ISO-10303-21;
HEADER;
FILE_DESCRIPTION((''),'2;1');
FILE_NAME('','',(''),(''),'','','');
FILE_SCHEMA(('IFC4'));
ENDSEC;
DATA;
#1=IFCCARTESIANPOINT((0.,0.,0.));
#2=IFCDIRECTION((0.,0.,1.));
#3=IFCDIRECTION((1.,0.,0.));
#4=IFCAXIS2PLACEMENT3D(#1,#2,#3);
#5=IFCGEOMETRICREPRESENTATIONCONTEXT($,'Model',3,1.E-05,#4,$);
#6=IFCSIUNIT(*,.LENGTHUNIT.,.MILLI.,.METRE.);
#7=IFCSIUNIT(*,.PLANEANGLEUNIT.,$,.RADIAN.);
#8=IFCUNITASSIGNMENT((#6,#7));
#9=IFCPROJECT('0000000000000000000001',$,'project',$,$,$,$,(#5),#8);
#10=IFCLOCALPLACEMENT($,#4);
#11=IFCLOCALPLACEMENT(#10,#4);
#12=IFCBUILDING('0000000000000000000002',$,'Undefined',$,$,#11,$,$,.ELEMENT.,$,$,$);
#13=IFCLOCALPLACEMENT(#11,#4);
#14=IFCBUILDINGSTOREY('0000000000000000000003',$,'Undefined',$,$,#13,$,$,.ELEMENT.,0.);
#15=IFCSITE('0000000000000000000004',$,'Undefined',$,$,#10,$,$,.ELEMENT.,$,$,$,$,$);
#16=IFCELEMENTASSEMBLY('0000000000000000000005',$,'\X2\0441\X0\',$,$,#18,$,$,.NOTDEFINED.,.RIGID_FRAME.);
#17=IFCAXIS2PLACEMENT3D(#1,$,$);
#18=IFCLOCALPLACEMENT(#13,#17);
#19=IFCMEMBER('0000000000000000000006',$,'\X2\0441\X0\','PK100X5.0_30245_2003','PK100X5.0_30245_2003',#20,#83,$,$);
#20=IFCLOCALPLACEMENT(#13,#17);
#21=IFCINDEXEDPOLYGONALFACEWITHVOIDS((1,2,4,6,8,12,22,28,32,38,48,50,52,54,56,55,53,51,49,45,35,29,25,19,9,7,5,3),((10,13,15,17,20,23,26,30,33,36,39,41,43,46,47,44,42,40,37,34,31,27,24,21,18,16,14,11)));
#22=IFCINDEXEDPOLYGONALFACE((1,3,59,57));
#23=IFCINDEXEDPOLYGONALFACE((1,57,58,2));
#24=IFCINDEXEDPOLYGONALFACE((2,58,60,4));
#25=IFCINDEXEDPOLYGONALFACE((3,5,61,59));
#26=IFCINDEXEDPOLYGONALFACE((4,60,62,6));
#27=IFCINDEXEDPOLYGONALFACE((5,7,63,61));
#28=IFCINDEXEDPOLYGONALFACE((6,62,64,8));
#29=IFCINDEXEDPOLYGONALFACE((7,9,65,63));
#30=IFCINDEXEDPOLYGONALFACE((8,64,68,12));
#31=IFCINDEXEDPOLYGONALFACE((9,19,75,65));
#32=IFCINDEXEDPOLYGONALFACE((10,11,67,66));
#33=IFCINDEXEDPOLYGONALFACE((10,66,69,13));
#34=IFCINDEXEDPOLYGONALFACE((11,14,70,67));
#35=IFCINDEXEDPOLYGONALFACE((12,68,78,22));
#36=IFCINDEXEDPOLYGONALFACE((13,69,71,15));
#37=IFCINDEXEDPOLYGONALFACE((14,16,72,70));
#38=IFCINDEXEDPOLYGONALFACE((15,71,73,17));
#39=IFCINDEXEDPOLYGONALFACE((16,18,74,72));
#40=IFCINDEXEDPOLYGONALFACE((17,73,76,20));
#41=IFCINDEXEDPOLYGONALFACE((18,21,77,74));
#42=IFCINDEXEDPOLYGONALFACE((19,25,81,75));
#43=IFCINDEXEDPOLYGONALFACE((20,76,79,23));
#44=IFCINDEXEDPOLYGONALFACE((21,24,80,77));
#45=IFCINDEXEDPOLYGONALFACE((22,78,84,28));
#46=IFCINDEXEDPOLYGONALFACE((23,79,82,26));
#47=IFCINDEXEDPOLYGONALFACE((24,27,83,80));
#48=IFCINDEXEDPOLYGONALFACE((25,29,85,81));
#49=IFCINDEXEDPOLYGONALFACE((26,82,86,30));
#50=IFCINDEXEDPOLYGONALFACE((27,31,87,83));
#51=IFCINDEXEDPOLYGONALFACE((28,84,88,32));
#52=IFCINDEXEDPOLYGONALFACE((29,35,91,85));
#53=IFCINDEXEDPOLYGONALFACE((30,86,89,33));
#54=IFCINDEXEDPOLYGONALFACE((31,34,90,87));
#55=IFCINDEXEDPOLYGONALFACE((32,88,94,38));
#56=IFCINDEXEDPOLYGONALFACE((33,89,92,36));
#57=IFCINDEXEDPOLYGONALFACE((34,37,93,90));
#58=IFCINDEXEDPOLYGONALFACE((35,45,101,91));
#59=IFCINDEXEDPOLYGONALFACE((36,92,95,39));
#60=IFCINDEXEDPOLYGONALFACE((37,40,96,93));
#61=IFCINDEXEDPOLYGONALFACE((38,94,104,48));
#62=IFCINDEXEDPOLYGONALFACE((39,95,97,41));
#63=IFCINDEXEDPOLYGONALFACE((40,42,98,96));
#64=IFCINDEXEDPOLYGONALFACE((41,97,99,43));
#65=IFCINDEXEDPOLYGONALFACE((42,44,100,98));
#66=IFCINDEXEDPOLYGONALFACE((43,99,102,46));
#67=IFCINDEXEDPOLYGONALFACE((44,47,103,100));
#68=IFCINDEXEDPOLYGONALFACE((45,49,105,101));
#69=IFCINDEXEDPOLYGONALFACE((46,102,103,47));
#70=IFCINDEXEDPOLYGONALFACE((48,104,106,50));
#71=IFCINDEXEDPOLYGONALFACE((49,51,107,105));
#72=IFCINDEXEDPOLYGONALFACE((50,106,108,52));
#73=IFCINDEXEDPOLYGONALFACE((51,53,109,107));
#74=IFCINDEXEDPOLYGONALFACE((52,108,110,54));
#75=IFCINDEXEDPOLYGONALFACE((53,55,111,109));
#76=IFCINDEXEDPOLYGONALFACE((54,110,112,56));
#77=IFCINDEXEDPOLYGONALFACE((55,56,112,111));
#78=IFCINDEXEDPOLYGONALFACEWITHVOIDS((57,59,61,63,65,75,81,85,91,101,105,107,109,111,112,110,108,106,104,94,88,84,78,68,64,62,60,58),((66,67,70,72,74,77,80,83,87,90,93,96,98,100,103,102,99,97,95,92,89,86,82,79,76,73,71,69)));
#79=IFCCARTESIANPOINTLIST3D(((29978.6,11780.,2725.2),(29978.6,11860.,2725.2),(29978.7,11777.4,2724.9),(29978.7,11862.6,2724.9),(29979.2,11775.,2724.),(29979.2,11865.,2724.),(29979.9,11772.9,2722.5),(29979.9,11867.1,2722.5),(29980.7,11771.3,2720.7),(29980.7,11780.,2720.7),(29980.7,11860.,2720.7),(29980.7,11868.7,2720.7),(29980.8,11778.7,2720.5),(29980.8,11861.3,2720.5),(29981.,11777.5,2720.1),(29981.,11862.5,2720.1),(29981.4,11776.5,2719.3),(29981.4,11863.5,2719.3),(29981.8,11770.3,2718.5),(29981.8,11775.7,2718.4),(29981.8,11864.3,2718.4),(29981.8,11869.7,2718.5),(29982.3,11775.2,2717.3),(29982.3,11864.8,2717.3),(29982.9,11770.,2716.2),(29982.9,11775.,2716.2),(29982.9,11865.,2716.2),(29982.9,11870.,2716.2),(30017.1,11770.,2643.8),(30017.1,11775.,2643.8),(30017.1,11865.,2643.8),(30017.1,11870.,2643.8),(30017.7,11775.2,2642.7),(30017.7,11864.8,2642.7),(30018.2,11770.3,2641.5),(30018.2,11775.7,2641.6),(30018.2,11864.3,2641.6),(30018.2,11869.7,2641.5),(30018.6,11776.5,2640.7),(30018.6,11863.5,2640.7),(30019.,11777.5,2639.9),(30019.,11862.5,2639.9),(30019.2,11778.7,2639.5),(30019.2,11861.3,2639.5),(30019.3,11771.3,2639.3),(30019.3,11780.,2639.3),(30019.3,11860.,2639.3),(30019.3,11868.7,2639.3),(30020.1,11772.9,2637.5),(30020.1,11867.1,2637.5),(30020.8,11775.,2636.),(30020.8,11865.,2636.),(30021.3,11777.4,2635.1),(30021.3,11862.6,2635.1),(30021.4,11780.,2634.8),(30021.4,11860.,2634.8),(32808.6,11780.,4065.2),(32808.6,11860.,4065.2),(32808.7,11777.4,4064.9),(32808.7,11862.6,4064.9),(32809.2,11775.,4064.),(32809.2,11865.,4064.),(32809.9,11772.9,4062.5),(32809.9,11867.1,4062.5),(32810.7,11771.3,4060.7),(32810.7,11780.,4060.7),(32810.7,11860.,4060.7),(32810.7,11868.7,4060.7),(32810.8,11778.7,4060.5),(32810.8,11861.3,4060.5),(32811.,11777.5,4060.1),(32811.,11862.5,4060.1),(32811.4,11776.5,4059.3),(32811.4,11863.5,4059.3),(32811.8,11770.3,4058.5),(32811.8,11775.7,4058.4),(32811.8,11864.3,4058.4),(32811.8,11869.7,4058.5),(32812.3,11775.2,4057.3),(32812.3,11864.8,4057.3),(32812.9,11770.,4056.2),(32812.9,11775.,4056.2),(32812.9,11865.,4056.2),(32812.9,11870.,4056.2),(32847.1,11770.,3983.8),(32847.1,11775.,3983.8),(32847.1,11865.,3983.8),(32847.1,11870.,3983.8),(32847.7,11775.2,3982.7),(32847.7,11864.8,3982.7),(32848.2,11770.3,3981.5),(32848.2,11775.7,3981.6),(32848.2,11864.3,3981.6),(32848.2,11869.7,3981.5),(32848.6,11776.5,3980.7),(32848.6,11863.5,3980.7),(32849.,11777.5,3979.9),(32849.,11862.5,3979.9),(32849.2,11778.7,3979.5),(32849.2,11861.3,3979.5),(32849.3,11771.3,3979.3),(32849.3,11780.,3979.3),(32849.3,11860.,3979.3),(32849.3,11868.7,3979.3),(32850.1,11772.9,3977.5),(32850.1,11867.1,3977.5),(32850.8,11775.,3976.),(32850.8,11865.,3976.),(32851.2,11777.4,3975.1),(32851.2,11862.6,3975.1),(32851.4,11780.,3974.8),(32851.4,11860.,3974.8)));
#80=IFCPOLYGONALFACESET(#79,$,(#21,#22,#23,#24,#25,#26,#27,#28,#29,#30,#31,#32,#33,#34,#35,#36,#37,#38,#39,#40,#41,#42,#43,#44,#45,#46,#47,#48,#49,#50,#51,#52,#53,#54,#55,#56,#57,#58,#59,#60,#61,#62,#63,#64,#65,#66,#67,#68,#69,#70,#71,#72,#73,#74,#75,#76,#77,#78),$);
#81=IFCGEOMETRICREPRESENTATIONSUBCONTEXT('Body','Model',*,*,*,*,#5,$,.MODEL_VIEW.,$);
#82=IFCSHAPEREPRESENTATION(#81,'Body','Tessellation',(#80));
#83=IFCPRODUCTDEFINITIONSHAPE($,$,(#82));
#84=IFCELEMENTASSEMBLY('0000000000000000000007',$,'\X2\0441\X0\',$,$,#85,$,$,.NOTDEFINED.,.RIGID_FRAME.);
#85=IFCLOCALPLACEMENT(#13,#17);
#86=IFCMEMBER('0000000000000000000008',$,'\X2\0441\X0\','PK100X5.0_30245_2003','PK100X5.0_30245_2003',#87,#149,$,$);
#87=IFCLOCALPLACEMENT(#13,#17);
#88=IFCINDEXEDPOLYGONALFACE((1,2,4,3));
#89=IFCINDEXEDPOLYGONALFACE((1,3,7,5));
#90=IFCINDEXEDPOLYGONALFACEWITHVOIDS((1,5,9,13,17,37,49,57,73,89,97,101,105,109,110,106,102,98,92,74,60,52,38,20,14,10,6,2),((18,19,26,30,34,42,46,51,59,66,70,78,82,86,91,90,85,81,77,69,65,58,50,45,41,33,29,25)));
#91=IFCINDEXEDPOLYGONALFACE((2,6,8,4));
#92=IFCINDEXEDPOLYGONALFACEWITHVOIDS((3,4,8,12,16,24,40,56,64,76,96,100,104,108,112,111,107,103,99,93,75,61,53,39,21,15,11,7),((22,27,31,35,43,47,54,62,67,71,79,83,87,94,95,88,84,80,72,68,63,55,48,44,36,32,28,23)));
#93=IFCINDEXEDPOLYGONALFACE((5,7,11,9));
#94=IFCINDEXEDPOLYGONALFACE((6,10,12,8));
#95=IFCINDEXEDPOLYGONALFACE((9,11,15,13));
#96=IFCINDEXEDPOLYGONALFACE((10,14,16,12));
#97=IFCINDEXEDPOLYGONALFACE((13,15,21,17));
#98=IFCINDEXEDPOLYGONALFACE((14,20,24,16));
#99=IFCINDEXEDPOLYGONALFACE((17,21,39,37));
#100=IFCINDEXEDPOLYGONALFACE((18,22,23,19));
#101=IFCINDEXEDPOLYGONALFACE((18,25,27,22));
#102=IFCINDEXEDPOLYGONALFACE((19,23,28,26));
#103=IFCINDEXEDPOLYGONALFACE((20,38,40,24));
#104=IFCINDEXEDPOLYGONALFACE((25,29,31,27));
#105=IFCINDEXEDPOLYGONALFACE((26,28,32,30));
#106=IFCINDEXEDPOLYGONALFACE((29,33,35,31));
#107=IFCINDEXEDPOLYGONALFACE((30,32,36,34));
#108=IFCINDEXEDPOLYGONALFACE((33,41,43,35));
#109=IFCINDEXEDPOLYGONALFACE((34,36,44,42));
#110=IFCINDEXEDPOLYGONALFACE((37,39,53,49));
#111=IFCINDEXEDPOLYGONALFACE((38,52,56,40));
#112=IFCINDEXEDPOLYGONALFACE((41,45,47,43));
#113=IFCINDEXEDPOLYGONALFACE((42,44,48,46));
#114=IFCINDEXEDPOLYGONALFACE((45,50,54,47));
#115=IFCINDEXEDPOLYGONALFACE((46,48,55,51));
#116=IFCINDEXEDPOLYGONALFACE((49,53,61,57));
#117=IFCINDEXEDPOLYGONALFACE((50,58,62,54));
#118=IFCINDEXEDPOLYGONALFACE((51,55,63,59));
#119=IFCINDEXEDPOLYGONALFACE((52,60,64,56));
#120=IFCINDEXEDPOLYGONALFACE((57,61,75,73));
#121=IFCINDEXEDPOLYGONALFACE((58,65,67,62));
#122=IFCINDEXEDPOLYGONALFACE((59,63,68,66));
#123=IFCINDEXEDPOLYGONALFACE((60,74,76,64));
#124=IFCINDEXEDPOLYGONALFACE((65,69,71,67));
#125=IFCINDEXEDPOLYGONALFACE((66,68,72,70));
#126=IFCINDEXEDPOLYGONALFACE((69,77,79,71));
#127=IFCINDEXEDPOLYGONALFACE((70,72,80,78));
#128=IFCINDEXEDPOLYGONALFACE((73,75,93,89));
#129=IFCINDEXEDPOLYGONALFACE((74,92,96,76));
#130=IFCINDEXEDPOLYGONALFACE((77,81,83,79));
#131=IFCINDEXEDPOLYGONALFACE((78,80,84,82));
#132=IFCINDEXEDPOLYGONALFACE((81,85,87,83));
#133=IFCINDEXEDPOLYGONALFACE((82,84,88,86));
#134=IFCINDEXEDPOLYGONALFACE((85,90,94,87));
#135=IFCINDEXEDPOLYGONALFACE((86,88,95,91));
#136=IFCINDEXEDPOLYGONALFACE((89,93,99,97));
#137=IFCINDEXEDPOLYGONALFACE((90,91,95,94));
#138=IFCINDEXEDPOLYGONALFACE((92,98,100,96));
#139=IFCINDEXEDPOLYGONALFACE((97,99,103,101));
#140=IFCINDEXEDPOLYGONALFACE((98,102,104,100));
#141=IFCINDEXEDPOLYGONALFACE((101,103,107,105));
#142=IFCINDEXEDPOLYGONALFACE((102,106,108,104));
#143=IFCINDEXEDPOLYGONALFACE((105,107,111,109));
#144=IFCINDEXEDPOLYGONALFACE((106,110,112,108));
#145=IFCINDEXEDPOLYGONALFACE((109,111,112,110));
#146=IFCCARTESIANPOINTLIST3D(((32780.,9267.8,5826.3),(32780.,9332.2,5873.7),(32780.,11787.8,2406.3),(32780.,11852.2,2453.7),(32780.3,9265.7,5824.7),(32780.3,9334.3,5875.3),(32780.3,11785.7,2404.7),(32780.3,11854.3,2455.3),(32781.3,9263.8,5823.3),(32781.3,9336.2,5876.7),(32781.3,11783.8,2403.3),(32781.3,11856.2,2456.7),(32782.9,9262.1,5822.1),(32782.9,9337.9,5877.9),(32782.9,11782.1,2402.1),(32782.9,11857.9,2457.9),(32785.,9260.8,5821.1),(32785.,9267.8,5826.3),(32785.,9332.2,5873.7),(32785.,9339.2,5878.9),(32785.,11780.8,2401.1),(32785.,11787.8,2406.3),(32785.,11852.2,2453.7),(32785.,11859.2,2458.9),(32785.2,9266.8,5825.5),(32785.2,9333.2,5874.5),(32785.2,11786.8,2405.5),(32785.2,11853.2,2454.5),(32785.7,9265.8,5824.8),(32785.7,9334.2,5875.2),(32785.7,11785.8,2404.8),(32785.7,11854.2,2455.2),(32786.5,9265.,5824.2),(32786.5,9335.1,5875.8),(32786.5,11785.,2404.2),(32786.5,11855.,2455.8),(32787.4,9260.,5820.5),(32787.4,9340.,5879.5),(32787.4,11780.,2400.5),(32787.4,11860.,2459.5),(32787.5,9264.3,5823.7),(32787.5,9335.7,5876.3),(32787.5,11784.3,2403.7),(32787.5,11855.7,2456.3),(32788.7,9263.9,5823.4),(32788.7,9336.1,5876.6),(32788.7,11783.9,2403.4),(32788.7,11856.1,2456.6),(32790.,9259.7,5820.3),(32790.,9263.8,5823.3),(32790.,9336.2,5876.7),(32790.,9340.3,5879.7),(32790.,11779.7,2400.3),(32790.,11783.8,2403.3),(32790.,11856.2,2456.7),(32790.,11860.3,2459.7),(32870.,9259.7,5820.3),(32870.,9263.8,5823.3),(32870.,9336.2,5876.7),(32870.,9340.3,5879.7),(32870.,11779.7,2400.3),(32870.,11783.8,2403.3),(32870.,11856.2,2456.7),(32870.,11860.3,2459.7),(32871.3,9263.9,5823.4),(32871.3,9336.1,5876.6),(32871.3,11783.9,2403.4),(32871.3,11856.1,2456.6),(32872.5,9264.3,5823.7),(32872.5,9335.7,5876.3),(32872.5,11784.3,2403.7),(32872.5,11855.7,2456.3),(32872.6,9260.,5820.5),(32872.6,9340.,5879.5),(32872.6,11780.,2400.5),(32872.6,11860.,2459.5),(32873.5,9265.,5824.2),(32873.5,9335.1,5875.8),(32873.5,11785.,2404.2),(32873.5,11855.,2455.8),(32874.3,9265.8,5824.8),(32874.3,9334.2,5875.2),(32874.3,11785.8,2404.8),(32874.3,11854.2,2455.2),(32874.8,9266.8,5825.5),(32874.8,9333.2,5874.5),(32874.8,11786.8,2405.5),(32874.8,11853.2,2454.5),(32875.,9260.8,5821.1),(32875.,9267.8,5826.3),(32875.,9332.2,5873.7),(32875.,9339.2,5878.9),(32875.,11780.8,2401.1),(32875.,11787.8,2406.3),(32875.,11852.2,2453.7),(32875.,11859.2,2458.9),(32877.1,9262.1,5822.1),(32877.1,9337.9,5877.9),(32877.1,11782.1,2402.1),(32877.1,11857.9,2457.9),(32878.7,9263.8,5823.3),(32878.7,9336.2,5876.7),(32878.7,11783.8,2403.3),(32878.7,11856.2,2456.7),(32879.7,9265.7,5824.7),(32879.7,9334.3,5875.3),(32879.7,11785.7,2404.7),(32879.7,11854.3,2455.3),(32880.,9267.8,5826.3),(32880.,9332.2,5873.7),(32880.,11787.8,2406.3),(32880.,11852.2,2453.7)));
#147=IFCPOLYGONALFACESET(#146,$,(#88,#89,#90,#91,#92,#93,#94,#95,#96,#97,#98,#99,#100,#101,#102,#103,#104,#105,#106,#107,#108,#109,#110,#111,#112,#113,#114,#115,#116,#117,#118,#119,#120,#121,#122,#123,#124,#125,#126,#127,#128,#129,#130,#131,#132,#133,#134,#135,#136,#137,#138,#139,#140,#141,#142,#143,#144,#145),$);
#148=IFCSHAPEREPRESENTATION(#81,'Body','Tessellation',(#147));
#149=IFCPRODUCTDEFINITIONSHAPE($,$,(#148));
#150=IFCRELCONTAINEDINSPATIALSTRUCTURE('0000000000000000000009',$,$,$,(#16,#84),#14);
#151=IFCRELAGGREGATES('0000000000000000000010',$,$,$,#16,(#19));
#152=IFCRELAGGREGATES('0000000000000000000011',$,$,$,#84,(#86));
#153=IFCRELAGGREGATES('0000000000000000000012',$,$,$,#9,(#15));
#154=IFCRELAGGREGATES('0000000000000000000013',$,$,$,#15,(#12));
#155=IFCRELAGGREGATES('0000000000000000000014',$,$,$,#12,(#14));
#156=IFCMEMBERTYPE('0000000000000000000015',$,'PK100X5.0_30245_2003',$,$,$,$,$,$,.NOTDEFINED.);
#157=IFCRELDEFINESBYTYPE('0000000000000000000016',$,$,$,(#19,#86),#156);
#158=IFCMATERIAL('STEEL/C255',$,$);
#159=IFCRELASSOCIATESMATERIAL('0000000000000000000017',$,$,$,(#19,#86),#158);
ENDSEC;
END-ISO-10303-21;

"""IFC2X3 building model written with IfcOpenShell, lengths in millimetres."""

from ifc_helpers import new_model, si_unit, frame, origin_with_axes, origin_2d_with_axis, place, context, subcontext, project, spatial, hollow_rectangle, extrude, material, type_object, element, aggregate, save


model = new_model("IFC2X3")

# Units and contexts
model_context = context("Model", 3, precision=1e-05, world=origin_with_axes())
body_context = subcontext(model_context, "Body", "Model", "MODEL_VIEW")
ifc_project = project(units=[si_unit("LENGTHUNIT", "METRE", prefix="MILLI"), si_unit("PLANEANGLEUNIT", "RADIAN")], contexts=[model_context])

# Site, building, storey
site_placement = place(None, origin_with_axes())
site = spatial("IfcSite", under=ifc_project, at=site_placement, Name="Undefined", CompositionType="ELEMENT")
building_placement = place(site_placement, origin_with_axes())
building = spatial("IfcBuilding", under=site, at=building_placement, Name="Undefined", CompositionType="ELEMENT")
storey_placement = place(building_placement, origin_with_axes())
storey = spatial("IfcBuildingStorey", under=building, at=storey_placement, Name="Undefined", CompositionType="ELEMENT", Elevation=0.0)

# Shared definitions
ifc_material_1 = material(Name="STEEL/C255")

# Element assemblies, members
member_type = type_object("IfcMemberType", Name="PK100X5.0_30245_2003", PredefinedType="NOTDEFINED")
assembly_1_placement = place(storey_placement, origin_with_axes())
assembly_1 = element("IfcElementAssembly", 1, at=assembly_1_placement, inside=storey, Name="с", AssemblyPlace="NOTDEFINED", PredefinedType="RIGID_FRAME")
member_1_placement = place(assembly_1_placement, frame((32830.0, 11820.0, 4020.0), z_axis=(0.0, -1.0, 0.0), x_axis=(-0.903803, 0.0, -0.427949)))
member_1 = element("IfcMember", 2, at=member_1_placement, type_object=member_type, material=ifc_material_1, Name="с", Description="PK100X5.0_30245_2003", ObjectType="PK100X5.0_30245_2003", context=body_context, shape_type="SweptSolid", body=[
    extrude(hollow_rectangle(XDim=100.0, YDim=100.0, WallThickness=5.0, InnerFilletRadius=5.0, OuterFilletRadius=10.0, at=origin_2d_with_axis()), frame((3131.2, 0.0, 0.0), z_axis=(-1.0, 0.0, 0.0), x_axis=(0.0, -1.0, 0.0)), (0.0, 0.0, 1.0), 3131.2),
])
aggregate(assembly_1, [member_1])
assembly_2_placement = place(storey_placement, origin_with_axes())
assembly_2 = element("IfcElementAssembly", 3, at=assembly_2_placement, inside=storey, Name="с", AssemblyPlace="NOTDEFINED", PredefinedType="RIGID_FRAME")
member_2_placement = place(assembly_2_placement, frame((32830.0, 9300.0, 5850.0), z_axis=(-1.0, 0.0, 0.0), x_axis=(0.0, 0.593199, -0.805056)))
member_2 = element("IfcMember", 4, at=member_2_placement, type_object=member_type, material=ifc_material_1, Name="с", Description="PK100X5.0_30245_2003", ObjectType="PK100X5.0_30245_2003", context=body_context, shape_type="SweptSolid", body=[
    extrude(hollow_rectangle(XDim=100.0, YDim=100.0, WallThickness=5.0, InnerFilletRadius=5.0, OuterFilletRadius=10.0, at=origin_2d_with_axis()), frame((4248.2, 0.0, 0.0), z_axis=(-1.0, 0.0, 0.0), x_axis=(0.0, -1.0, 0.0)), (0.0, 0.0, 1.0), 4248.1),
])
aggregate(assembly_2, [member_2])

save(model, "model.ifc")
